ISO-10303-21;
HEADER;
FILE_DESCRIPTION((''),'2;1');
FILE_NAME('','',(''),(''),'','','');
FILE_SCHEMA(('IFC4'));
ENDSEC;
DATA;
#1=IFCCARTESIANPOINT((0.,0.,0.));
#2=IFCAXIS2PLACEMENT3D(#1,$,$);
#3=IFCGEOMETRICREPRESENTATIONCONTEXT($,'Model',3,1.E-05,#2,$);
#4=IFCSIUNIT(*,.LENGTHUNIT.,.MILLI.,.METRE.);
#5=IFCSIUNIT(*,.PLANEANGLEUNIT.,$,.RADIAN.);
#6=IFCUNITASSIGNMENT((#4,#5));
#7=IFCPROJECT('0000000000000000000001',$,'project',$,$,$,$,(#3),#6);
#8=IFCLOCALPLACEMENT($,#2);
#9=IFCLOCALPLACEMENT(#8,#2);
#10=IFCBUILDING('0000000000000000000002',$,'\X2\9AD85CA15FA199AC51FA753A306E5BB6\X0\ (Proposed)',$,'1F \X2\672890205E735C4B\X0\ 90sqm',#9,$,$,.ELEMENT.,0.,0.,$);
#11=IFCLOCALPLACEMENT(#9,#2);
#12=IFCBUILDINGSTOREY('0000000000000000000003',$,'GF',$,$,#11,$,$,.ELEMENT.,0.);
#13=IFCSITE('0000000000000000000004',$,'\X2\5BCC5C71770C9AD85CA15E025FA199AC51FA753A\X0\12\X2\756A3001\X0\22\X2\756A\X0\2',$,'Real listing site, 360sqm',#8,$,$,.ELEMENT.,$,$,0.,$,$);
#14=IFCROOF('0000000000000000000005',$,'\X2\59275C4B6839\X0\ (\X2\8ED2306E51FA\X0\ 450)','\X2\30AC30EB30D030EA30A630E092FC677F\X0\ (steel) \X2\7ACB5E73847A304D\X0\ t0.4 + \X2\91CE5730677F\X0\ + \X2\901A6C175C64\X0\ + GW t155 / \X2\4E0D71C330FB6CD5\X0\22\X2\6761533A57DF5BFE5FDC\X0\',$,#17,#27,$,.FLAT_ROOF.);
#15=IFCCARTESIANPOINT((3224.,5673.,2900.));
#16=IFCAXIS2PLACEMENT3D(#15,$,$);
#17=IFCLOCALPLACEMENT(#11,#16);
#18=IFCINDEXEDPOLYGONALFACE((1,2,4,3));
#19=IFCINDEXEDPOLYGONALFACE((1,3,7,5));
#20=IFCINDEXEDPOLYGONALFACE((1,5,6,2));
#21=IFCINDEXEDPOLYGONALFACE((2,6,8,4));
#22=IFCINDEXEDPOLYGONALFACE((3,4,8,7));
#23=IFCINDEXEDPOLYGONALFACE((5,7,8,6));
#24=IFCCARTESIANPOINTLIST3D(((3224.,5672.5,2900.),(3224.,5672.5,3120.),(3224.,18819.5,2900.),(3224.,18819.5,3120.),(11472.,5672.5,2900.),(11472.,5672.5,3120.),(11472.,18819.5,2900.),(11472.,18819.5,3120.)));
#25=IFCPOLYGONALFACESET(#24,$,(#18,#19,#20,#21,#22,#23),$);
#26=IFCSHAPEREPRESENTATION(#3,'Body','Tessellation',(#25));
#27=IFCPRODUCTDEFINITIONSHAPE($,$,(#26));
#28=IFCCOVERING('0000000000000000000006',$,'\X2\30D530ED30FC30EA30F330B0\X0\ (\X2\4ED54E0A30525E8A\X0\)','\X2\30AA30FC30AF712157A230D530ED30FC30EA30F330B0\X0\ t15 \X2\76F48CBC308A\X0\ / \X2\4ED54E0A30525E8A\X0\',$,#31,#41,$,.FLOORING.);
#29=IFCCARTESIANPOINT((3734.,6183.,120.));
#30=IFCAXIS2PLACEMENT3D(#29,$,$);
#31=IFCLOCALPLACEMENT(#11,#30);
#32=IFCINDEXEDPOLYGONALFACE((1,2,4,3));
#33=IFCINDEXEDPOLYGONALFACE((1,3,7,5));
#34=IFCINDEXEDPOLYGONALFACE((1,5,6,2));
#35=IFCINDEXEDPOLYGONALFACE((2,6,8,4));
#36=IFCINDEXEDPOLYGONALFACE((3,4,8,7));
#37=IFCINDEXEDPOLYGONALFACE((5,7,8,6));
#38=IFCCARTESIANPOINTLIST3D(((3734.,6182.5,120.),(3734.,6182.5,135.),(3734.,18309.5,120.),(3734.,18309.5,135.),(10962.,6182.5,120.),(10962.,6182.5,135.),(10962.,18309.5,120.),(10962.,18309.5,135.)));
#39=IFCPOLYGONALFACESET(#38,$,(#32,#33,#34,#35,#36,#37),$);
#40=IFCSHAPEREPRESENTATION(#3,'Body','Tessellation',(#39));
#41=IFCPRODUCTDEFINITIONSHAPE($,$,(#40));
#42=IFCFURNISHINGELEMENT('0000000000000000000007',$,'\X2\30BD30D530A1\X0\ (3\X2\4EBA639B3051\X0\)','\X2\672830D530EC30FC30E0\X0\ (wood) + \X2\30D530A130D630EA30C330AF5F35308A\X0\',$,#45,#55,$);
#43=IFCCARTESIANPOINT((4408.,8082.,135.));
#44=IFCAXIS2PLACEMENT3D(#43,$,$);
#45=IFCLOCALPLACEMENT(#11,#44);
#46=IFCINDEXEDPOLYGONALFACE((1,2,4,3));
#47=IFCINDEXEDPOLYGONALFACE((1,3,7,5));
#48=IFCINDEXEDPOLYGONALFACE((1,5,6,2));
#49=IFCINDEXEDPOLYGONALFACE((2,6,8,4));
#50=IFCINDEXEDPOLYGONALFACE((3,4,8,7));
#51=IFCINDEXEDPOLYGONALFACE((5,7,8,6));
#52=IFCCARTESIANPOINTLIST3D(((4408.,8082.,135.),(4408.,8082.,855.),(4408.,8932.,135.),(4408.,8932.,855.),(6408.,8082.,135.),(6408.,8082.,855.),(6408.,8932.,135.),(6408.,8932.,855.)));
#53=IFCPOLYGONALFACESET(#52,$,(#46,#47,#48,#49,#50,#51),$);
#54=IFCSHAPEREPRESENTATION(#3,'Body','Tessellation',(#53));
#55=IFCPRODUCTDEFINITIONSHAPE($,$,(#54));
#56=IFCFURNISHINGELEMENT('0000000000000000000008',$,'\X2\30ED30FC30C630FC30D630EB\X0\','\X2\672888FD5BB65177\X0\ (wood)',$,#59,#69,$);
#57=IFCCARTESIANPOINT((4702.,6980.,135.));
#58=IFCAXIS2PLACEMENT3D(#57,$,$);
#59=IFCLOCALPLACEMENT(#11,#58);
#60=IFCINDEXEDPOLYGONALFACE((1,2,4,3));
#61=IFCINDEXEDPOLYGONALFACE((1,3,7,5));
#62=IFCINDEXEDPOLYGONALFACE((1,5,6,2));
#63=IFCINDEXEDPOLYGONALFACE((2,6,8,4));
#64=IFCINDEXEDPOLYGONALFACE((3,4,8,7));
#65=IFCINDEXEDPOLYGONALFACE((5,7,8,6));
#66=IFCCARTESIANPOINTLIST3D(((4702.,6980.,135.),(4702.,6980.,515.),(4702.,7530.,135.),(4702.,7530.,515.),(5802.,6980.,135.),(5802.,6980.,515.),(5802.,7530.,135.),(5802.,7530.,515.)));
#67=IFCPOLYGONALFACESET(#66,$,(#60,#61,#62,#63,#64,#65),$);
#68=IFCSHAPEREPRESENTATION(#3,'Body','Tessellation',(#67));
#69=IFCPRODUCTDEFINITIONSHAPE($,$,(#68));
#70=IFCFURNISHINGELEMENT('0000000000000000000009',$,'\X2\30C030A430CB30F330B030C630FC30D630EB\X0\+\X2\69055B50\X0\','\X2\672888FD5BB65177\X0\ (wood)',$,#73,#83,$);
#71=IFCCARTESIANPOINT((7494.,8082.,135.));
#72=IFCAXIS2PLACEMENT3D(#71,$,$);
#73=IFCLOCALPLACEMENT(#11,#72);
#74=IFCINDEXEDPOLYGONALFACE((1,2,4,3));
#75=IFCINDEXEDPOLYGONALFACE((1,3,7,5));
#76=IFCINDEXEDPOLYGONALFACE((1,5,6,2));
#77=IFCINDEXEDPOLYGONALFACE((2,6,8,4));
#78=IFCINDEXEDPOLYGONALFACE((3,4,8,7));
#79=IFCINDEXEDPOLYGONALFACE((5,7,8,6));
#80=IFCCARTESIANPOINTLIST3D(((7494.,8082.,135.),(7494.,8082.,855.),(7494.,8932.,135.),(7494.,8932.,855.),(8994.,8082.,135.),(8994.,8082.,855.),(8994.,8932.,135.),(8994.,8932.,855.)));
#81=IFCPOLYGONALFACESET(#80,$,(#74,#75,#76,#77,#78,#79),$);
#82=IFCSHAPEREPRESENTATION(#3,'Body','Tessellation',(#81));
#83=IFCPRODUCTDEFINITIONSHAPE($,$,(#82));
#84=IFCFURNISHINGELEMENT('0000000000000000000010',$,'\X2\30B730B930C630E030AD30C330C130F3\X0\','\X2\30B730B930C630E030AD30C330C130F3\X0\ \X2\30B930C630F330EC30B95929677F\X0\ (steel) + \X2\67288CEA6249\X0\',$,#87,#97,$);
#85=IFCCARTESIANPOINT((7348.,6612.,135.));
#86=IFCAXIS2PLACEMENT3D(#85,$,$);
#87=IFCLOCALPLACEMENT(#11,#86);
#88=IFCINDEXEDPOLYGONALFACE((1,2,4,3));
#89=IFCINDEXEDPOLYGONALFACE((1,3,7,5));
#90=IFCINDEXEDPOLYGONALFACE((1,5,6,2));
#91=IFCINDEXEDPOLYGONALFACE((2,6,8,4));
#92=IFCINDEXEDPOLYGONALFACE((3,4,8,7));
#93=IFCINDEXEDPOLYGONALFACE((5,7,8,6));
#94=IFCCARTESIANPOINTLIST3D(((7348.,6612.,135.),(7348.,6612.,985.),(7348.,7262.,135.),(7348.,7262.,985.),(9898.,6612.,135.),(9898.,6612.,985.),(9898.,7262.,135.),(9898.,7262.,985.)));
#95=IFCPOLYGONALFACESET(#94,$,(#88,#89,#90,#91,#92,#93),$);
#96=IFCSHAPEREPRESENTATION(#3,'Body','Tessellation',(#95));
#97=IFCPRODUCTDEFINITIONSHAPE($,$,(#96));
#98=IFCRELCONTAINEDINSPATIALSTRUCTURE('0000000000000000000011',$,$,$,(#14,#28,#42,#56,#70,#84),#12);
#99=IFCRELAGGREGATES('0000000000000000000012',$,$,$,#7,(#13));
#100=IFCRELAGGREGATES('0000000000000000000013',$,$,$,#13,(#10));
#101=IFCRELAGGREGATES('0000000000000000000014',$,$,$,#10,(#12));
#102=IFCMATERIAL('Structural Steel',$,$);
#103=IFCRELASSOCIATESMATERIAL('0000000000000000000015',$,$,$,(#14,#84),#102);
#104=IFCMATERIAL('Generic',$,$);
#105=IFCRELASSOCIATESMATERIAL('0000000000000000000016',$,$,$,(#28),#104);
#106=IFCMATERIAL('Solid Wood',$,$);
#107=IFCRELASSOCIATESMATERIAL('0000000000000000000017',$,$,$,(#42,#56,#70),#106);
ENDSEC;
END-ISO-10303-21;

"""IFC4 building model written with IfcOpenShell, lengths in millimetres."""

from ifc_helpers import new_model, si_unit, frame, frame_2d, origin, place, context, project, spatial, rectangle, extrude, material, element, save


model = new_model("IFC4")

# Units and contexts
model_context = context("Model", 3, precision=1e-05, world=origin())
ifc_project = project(units=[si_unit("LENGTHUNIT", "METRE", prefix="MILLI"), si_unit("PLANEANGLEUNIT", "RADIAN")], contexts=[model_context])

# Site, building, storey
site_placement = place(None, origin())
site = spatial("IfcSite", under=ifc_project, at=site_placement, Name="富山県高岡市御馬出町12番、22番2", ObjectType="Real listing site, 360sqm", CompositionType="ELEMENT", RefElevation=0.0)
building_placement = place(site_placement, origin())
building = spatial("IfcBuilding", under=site, at=building_placement, Name="高岡御馬出町の家 (Proposed)", ObjectType="1F 木造平屋 90sqm", CompositionType="ELEMENT", ElevationOfRefHeight=0.0, ElevationOfTerrain=0.0)
storey_placement = place(building_placement, origin())
storey = spatial("IfcBuildingStorey", under=building, at=storey_placement, Name="GF", CompositionType="ELEMENT", Elevation=0.0)

# Shared definitions
ifc_material_1 = material(Name="Solid Wood")

# Roof
ifc_material_2 = material(Name="Structural Steel")
roof_placement = place(storey_placement, frame((3224.0, 5673.0, 2900.0)))
element("IfcRoof", 1, at=roof_placement, inside=storey, material=ifc_material_2, Name="大屋根 (軒の出 450)", Description="ガルバリウム鋼板 (steel) 立平葺き t0.4 + 野地板 + 通気層 + GW t155 / 不燃・法22条区域対応", PredefinedType="FLAT_ROOF", context=model_context, shape_type="SweptSolid", body=[
    extrude(rectangle(XDim=8248.0, YDim=13147.0, at=frame_2d((4124.0, 6573.0))), frame((3224.0, 5673.0, 2900.0)), (0.0, 0.0, 1.0), 220.0),
])

# Covering
ifc_material_3 = material(Name="Generic")
covering_placement = place(storey_placement, frame((3734.0, 6183.0, 120.0)))
element("IfcCovering", 2, at=covering_placement, inside=storey, material=ifc_material_3, Name="フローリング (仕上げ床)", Description="オーク無垢フローリング t15 直貼り / 仕上げ床", PredefinedType="FLOORING", context=model_context, shape_type="SweptSolid", body=[
    extrude(rectangle(XDim=7228.0, YDim=12127.0, at=frame_2d((3614.0, 6063.0))), frame((3734.0, 6183.0, 120.0)), (0.0, 0.0, 1.0), 15.0),
])

# Furnishing elements
furnishing_1_placement = place(storey_placement, frame((4408.0, 8082.0, 135.0)))
element("IfcFurnishingElement", 3, at=furnishing_1_placement, inside=storey, material=ifc_material_1, Name="ソファ (3人掛け)", Description="木フレーム (wood) + ファブリック張り", context=model_context, shape_type="SweptSolid", body=[
    extrude(rectangle(XDim=2000.0, YDim=850.0, at=frame_2d((1000.0, 425.0))), frame((4408.0, 8082.0, 135.0)), (0.0, 0.0, 1.0), 720.0),
])
furnishing_2_placement = place(storey_placement, frame((4702.0, 6980.0, 135.0)))
element("IfcFurnishingElement", 4, at=furnishing_2_placement, inside=storey, material=ifc_material_1, Name="ローテーブル", Description="木製家具 (wood)", context=model_context, shape_type="SweptSolid", body=[
    extrude(rectangle(XDim=1100.0, YDim=550.0, at=frame_2d((550.0, 275.0))), frame((4702.0, 6980.0, 135.0)), (0.0, 0.0, 1.0), 380.0),
])
furnishing_3_placement = place(storey_placement, frame((7494.0, 8082.0, 135.0)))
element("IfcFurnishingElement", 5, at=furnishing_3_placement, inside=storey, material=ifc_material_1, Name="ダイニングテーブル+椅子", Description="木製家具 (wood)", context=model_context, shape_type="SweptSolid", body=[
    extrude(rectangle(XDim=1500.0, YDim=850.0, at=frame_2d((750.0, 425.0))), frame((7494.0, 8082.0, 135.0)), (0.0, 0.0, 1.0), 720.0),
])
furnishing_4_placement = place(storey_placement, frame((7348.0, 6612.0, 135.0)))
element("IfcFurnishingElement", 6, at=furnishing_4_placement, inside=storey, material=ifc_material_2, Name="システムキッチン", Description="システムキッチン ステンレス天板 (steel) + 木質扉", context=model_context, shape_type="SweptSolid", body=[
    extrude(rectangle(XDim=2550.0, YDim=650.0, at=frame_2d((1275.0, 325.0))), frame((7348.0, 6612.0, 135.0)), (0.0, 0.0, 1.0), 850.0),
])

save(model, "model.ifc")
